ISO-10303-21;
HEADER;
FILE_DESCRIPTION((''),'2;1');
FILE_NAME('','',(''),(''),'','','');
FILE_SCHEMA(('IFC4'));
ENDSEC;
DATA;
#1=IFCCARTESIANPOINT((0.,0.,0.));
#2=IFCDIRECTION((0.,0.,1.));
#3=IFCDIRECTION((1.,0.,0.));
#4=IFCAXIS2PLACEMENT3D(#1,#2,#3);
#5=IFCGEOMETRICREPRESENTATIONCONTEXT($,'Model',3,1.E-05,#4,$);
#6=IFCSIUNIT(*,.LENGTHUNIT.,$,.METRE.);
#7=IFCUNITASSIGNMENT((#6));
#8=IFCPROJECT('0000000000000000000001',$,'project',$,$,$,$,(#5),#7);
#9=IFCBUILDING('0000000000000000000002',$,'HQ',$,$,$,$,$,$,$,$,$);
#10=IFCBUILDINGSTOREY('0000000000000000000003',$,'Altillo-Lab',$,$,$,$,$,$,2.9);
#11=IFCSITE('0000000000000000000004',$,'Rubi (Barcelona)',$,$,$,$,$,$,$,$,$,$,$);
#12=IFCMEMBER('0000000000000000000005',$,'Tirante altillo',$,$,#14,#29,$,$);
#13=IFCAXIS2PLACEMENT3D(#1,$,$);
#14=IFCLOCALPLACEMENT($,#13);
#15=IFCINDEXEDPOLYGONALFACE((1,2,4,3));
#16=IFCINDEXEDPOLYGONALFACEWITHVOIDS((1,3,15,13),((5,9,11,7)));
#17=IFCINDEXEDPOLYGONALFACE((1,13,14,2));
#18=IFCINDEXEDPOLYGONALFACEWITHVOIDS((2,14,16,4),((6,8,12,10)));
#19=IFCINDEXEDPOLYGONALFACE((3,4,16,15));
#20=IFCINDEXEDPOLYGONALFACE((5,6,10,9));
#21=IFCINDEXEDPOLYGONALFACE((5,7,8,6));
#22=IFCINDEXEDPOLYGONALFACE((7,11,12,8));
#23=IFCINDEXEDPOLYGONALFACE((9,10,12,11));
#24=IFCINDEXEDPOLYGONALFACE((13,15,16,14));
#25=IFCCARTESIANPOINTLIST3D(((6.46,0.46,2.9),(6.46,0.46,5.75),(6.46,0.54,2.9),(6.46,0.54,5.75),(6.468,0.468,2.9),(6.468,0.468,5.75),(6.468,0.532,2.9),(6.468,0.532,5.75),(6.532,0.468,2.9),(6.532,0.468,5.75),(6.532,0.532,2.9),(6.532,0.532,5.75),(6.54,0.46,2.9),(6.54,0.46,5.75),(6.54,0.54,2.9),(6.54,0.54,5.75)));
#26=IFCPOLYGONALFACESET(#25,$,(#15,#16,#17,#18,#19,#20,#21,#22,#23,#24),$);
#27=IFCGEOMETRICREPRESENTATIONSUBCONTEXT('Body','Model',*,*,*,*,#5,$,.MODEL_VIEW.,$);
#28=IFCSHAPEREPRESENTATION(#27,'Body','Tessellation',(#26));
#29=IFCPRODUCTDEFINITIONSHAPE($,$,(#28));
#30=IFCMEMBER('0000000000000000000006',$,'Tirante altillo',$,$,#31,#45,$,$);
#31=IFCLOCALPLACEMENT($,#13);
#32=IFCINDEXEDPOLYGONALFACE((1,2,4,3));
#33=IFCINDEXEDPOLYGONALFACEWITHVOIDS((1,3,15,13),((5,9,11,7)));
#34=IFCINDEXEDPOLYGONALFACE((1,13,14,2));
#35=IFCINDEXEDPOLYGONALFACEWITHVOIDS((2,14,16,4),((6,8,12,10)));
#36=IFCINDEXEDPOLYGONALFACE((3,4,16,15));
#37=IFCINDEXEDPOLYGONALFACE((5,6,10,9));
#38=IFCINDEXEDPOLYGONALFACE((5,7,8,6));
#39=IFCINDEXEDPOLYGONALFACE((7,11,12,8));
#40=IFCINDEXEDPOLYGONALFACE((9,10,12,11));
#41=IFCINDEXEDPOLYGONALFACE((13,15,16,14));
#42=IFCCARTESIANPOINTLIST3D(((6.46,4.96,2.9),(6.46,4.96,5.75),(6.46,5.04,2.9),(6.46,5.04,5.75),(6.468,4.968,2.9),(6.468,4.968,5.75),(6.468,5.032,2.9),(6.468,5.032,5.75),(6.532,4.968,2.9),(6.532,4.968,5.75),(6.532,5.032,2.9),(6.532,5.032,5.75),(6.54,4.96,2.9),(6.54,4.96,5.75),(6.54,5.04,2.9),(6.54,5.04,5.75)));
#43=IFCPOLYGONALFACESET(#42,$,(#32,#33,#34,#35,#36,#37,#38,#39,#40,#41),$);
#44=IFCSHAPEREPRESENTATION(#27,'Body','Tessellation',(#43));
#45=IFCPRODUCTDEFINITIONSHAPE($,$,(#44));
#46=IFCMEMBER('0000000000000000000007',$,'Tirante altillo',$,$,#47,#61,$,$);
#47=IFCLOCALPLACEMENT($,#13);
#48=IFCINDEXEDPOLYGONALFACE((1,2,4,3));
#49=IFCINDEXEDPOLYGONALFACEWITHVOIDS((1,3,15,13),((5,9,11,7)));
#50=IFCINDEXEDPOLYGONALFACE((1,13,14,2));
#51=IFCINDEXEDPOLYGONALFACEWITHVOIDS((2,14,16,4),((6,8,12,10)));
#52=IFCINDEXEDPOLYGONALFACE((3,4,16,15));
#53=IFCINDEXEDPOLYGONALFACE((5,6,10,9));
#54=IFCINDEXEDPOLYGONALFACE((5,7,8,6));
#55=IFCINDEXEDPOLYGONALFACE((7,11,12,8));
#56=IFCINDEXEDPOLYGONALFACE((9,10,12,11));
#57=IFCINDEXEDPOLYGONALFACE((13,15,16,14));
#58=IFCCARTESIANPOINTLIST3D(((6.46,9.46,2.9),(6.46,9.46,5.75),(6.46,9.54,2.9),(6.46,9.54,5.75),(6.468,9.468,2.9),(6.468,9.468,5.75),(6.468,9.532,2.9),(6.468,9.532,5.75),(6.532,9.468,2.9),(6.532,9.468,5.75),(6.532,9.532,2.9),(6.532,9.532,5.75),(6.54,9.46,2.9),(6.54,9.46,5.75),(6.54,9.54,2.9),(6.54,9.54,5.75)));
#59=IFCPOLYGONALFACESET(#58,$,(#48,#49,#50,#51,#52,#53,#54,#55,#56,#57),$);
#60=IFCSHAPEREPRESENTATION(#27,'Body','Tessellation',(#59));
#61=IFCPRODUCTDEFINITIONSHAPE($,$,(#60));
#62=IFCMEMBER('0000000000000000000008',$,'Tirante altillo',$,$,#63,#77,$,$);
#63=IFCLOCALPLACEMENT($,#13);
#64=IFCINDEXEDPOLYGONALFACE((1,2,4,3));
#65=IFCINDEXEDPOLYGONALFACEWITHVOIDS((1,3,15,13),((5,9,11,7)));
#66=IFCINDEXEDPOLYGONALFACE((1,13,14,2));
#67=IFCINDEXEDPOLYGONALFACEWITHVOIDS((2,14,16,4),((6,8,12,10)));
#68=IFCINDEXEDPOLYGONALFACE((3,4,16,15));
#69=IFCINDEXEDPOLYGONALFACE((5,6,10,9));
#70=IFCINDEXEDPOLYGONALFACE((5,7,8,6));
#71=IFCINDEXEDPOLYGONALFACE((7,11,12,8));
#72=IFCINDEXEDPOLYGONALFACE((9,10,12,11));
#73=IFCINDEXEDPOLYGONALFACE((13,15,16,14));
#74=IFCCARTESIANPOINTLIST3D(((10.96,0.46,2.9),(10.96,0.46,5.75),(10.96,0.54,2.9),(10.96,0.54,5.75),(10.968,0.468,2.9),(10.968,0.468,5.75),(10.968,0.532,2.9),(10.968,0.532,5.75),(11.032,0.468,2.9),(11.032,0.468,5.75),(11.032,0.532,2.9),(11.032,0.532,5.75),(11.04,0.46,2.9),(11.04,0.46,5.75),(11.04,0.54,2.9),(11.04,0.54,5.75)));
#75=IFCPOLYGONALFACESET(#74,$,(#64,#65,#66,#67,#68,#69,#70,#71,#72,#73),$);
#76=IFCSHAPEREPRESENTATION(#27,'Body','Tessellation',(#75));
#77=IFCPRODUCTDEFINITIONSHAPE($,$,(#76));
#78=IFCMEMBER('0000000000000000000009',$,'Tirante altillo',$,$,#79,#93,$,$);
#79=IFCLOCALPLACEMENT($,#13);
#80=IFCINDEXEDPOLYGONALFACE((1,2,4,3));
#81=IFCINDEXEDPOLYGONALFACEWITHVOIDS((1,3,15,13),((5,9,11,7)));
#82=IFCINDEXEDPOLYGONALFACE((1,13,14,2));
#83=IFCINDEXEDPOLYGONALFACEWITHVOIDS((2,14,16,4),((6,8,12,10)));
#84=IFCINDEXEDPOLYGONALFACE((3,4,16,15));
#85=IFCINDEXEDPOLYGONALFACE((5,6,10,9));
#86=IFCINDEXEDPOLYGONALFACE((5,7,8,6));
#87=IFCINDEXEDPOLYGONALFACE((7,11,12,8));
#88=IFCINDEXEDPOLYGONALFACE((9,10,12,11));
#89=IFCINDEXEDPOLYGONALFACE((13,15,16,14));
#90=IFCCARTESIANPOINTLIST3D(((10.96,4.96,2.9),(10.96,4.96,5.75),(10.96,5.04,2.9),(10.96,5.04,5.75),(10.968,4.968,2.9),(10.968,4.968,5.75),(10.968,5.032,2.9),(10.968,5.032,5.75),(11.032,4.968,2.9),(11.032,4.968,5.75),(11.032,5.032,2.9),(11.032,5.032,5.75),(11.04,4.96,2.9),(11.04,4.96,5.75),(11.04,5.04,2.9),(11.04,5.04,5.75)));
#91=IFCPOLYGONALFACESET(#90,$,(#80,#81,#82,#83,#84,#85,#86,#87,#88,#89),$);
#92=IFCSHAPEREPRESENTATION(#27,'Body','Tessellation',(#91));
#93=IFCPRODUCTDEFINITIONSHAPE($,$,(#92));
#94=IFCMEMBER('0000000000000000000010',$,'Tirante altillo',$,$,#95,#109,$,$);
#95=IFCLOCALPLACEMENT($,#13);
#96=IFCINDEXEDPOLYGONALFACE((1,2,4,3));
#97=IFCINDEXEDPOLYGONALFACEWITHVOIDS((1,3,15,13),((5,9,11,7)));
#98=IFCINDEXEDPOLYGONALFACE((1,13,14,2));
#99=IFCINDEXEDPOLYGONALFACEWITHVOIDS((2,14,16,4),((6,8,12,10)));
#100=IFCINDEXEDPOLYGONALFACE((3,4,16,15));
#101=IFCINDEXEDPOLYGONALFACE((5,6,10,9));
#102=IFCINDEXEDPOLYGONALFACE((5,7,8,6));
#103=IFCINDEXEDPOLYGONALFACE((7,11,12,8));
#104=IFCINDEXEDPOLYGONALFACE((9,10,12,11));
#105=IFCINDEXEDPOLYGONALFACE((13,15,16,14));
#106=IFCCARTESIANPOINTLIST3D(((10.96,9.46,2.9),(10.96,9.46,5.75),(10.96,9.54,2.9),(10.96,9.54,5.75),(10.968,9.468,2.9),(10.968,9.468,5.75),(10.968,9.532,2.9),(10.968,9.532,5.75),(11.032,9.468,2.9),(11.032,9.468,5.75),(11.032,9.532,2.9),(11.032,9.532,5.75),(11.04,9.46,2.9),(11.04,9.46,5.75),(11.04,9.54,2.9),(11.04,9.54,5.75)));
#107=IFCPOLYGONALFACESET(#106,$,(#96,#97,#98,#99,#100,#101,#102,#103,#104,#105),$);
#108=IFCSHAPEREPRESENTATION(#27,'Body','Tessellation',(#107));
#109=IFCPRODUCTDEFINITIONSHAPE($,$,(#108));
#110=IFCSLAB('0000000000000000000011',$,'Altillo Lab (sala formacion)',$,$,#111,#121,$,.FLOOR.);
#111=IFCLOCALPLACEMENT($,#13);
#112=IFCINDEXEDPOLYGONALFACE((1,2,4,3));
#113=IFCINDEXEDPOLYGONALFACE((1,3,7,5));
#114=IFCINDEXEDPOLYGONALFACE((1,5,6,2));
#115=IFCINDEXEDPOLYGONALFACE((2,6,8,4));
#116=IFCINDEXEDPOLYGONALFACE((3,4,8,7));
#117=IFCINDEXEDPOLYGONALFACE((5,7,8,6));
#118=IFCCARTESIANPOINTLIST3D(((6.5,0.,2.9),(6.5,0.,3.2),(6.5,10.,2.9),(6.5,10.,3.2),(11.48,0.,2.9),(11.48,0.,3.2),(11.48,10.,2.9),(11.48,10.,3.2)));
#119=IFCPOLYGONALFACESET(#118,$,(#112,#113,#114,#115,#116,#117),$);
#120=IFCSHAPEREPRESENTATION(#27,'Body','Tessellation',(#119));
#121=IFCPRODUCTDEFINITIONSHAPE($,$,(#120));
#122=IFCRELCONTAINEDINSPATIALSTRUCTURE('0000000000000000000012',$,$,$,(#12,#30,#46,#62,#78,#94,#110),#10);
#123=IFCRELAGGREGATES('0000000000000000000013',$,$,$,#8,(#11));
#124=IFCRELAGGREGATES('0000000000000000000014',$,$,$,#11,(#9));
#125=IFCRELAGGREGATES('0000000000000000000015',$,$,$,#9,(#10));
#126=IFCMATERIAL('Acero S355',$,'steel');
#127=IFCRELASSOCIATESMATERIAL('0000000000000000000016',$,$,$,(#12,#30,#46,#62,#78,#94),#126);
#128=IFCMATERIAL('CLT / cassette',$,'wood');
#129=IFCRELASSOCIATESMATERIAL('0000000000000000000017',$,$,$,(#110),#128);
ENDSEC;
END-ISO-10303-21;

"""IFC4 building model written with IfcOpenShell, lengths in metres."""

from ifc_helpers import new_model, si_unit, frame, origin_with_axes, place, context, subcontext, project, spatial, polyline, hollow_rectangle, outline, extrude, material, element, save


model = new_model("IFC4")

# Units and contexts
model_context = context("Model", 3, precision=1e-05, world=origin_with_axes())
body_context = subcontext(model_context, "Body", "Model", "MODEL_VIEW")
ifc_project = project(units=[si_unit("LENGTHUNIT", "METRE")], contexts=[model_context])

# Site, building, storey
site = spatial("IfcSite", under=ifc_project, Name="Rubi (Barcelona)")
building = spatial("IfcBuilding", under=site, Name="HQ")
storey = spatial("IfcBuildingStorey", under=building, Name="Altillo-Lab", Elevation=2.9)

# Members
ifc_material_1 = material(Name="Acero S355", Category="steel")
member_1_placement = place(None, origin_with_axes())
element("IfcMember", 1, at=member_1_placement, inside=storey, material=ifc_material_1, Name="Tirante altillo", context=body_context, shape_type="SweptSolid", body=[
    extrude(hollow_rectangle(XDim=0.08, YDim=0.08, WallThickness=0.008), frame((6.5, 0.5, 2.9), z_axis=(0.0, 0.0, 1.0), x_axis=(1.0, 0.0, 0.0)), (0.0, 0.0, 1.0), 2.85),
])
member_2_placement = place(None, origin_with_axes())
element("IfcMember", 2, at=member_2_placement, inside=storey, material=ifc_material_1, Name="Tirante altillo", context=body_context, shape_type="SweptSolid", body=[
    extrude(hollow_rectangle(XDim=0.08, YDim=0.08, WallThickness=0.008), frame((6.5, 5.0, 2.9), z_axis=(0.0, 0.0, 1.0), x_axis=(1.0, 0.0, 0.0)), (0.0, 0.0, 1.0), 2.85),
])
member_3_placement = place(None, origin_with_axes())
element("IfcMember", 3, at=member_3_placement, inside=storey, material=ifc_material_1, Name="Tirante altillo", context=body_context, shape_type="SweptSolid", body=[
    extrude(hollow_rectangle(XDim=0.08, YDim=0.08, WallThickness=0.008), frame((6.5, 9.5, 2.9), z_axis=(0.0, 0.0, 1.0), x_axis=(1.0, 0.0, 0.0)), (0.0, 0.0, 1.0), 2.85),
])
member_4_placement = place(None, origin_with_axes())
element("IfcMember", 4, at=member_4_placement, inside=storey, material=ifc_material_1, Name="Tirante altillo", context=body_context, shape_type="SweptSolid", body=[
    extrude(hollow_rectangle(XDim=0.08, YDim=0.08, WallThickness=0.008), frame((11.0, 0.5, 2.9), z_axis=(0.0, 0.0, 1.0), x_axis=(1.0, 0.0, 0.0)), (0.0, 0.0, 1.0), 2.85),
])
member_5_placement = place(None, origin_with_axes())
element("IfcMember", 5, at=member_5_placement, inside=storey, material=ifc_material_1, Name="Tirante altillo", context=body_context, shape_type="SweptSolid", body=[
    extrude(hollow_rectangle(XDim=0.08, YDim=0.08, WallThickness=0.008), frame((11.0, 5.0, 2.9), z_axis=(0.0, 0.0, 1.0), x_axis=(1.0, 0.0, 0.0)), (0.0, 0.0, 1.0), 2.85),
])
member_6_placement = place(None, origin_with_axes())
element("IfcMember", 6, at=member_6_placement, inside=storey, material=ifc_material_1, Name="Tirante altillo", context=body_context, shape_type="SweptSolid", body=[
    extrude(hollow_rectangle(XDim=0.08, YDim=0.08, WallThickness=0.008), frame((11.0, 9.5, 2.9), z_axis=(0.0, 0.0, 1.0), x_axis=(1.0, 0.0, 0.0)), (0.0, 0.0, 1.0), 2.85),
])

# Slab
ifc_material_2 = material(Name="CLT / cassette", Category="wood")
slab_placement = place(None, origin_with_axes())
element("IfcSlab", 7, at=slab_placement, inside=storey, material=ifc_material_2, Name="Altillo Lab (sala formacion)", PredefinedType="FLOOR", context=body_context, shape_type="SweptSolid", body=[
    extrude(outline(polyline([(6.5, 0.0, 0.0), (11.48, 0.0, 0.0), (11.48, 10.0, 0.0), (6.5, 10.0, 0.0), (6.5, 0.0, 0.0)])), frame((0.0, 0.0, 2.9)), (0.0, 0.0, 1.0), 0.3),
])

save(model, "model.ifc")
